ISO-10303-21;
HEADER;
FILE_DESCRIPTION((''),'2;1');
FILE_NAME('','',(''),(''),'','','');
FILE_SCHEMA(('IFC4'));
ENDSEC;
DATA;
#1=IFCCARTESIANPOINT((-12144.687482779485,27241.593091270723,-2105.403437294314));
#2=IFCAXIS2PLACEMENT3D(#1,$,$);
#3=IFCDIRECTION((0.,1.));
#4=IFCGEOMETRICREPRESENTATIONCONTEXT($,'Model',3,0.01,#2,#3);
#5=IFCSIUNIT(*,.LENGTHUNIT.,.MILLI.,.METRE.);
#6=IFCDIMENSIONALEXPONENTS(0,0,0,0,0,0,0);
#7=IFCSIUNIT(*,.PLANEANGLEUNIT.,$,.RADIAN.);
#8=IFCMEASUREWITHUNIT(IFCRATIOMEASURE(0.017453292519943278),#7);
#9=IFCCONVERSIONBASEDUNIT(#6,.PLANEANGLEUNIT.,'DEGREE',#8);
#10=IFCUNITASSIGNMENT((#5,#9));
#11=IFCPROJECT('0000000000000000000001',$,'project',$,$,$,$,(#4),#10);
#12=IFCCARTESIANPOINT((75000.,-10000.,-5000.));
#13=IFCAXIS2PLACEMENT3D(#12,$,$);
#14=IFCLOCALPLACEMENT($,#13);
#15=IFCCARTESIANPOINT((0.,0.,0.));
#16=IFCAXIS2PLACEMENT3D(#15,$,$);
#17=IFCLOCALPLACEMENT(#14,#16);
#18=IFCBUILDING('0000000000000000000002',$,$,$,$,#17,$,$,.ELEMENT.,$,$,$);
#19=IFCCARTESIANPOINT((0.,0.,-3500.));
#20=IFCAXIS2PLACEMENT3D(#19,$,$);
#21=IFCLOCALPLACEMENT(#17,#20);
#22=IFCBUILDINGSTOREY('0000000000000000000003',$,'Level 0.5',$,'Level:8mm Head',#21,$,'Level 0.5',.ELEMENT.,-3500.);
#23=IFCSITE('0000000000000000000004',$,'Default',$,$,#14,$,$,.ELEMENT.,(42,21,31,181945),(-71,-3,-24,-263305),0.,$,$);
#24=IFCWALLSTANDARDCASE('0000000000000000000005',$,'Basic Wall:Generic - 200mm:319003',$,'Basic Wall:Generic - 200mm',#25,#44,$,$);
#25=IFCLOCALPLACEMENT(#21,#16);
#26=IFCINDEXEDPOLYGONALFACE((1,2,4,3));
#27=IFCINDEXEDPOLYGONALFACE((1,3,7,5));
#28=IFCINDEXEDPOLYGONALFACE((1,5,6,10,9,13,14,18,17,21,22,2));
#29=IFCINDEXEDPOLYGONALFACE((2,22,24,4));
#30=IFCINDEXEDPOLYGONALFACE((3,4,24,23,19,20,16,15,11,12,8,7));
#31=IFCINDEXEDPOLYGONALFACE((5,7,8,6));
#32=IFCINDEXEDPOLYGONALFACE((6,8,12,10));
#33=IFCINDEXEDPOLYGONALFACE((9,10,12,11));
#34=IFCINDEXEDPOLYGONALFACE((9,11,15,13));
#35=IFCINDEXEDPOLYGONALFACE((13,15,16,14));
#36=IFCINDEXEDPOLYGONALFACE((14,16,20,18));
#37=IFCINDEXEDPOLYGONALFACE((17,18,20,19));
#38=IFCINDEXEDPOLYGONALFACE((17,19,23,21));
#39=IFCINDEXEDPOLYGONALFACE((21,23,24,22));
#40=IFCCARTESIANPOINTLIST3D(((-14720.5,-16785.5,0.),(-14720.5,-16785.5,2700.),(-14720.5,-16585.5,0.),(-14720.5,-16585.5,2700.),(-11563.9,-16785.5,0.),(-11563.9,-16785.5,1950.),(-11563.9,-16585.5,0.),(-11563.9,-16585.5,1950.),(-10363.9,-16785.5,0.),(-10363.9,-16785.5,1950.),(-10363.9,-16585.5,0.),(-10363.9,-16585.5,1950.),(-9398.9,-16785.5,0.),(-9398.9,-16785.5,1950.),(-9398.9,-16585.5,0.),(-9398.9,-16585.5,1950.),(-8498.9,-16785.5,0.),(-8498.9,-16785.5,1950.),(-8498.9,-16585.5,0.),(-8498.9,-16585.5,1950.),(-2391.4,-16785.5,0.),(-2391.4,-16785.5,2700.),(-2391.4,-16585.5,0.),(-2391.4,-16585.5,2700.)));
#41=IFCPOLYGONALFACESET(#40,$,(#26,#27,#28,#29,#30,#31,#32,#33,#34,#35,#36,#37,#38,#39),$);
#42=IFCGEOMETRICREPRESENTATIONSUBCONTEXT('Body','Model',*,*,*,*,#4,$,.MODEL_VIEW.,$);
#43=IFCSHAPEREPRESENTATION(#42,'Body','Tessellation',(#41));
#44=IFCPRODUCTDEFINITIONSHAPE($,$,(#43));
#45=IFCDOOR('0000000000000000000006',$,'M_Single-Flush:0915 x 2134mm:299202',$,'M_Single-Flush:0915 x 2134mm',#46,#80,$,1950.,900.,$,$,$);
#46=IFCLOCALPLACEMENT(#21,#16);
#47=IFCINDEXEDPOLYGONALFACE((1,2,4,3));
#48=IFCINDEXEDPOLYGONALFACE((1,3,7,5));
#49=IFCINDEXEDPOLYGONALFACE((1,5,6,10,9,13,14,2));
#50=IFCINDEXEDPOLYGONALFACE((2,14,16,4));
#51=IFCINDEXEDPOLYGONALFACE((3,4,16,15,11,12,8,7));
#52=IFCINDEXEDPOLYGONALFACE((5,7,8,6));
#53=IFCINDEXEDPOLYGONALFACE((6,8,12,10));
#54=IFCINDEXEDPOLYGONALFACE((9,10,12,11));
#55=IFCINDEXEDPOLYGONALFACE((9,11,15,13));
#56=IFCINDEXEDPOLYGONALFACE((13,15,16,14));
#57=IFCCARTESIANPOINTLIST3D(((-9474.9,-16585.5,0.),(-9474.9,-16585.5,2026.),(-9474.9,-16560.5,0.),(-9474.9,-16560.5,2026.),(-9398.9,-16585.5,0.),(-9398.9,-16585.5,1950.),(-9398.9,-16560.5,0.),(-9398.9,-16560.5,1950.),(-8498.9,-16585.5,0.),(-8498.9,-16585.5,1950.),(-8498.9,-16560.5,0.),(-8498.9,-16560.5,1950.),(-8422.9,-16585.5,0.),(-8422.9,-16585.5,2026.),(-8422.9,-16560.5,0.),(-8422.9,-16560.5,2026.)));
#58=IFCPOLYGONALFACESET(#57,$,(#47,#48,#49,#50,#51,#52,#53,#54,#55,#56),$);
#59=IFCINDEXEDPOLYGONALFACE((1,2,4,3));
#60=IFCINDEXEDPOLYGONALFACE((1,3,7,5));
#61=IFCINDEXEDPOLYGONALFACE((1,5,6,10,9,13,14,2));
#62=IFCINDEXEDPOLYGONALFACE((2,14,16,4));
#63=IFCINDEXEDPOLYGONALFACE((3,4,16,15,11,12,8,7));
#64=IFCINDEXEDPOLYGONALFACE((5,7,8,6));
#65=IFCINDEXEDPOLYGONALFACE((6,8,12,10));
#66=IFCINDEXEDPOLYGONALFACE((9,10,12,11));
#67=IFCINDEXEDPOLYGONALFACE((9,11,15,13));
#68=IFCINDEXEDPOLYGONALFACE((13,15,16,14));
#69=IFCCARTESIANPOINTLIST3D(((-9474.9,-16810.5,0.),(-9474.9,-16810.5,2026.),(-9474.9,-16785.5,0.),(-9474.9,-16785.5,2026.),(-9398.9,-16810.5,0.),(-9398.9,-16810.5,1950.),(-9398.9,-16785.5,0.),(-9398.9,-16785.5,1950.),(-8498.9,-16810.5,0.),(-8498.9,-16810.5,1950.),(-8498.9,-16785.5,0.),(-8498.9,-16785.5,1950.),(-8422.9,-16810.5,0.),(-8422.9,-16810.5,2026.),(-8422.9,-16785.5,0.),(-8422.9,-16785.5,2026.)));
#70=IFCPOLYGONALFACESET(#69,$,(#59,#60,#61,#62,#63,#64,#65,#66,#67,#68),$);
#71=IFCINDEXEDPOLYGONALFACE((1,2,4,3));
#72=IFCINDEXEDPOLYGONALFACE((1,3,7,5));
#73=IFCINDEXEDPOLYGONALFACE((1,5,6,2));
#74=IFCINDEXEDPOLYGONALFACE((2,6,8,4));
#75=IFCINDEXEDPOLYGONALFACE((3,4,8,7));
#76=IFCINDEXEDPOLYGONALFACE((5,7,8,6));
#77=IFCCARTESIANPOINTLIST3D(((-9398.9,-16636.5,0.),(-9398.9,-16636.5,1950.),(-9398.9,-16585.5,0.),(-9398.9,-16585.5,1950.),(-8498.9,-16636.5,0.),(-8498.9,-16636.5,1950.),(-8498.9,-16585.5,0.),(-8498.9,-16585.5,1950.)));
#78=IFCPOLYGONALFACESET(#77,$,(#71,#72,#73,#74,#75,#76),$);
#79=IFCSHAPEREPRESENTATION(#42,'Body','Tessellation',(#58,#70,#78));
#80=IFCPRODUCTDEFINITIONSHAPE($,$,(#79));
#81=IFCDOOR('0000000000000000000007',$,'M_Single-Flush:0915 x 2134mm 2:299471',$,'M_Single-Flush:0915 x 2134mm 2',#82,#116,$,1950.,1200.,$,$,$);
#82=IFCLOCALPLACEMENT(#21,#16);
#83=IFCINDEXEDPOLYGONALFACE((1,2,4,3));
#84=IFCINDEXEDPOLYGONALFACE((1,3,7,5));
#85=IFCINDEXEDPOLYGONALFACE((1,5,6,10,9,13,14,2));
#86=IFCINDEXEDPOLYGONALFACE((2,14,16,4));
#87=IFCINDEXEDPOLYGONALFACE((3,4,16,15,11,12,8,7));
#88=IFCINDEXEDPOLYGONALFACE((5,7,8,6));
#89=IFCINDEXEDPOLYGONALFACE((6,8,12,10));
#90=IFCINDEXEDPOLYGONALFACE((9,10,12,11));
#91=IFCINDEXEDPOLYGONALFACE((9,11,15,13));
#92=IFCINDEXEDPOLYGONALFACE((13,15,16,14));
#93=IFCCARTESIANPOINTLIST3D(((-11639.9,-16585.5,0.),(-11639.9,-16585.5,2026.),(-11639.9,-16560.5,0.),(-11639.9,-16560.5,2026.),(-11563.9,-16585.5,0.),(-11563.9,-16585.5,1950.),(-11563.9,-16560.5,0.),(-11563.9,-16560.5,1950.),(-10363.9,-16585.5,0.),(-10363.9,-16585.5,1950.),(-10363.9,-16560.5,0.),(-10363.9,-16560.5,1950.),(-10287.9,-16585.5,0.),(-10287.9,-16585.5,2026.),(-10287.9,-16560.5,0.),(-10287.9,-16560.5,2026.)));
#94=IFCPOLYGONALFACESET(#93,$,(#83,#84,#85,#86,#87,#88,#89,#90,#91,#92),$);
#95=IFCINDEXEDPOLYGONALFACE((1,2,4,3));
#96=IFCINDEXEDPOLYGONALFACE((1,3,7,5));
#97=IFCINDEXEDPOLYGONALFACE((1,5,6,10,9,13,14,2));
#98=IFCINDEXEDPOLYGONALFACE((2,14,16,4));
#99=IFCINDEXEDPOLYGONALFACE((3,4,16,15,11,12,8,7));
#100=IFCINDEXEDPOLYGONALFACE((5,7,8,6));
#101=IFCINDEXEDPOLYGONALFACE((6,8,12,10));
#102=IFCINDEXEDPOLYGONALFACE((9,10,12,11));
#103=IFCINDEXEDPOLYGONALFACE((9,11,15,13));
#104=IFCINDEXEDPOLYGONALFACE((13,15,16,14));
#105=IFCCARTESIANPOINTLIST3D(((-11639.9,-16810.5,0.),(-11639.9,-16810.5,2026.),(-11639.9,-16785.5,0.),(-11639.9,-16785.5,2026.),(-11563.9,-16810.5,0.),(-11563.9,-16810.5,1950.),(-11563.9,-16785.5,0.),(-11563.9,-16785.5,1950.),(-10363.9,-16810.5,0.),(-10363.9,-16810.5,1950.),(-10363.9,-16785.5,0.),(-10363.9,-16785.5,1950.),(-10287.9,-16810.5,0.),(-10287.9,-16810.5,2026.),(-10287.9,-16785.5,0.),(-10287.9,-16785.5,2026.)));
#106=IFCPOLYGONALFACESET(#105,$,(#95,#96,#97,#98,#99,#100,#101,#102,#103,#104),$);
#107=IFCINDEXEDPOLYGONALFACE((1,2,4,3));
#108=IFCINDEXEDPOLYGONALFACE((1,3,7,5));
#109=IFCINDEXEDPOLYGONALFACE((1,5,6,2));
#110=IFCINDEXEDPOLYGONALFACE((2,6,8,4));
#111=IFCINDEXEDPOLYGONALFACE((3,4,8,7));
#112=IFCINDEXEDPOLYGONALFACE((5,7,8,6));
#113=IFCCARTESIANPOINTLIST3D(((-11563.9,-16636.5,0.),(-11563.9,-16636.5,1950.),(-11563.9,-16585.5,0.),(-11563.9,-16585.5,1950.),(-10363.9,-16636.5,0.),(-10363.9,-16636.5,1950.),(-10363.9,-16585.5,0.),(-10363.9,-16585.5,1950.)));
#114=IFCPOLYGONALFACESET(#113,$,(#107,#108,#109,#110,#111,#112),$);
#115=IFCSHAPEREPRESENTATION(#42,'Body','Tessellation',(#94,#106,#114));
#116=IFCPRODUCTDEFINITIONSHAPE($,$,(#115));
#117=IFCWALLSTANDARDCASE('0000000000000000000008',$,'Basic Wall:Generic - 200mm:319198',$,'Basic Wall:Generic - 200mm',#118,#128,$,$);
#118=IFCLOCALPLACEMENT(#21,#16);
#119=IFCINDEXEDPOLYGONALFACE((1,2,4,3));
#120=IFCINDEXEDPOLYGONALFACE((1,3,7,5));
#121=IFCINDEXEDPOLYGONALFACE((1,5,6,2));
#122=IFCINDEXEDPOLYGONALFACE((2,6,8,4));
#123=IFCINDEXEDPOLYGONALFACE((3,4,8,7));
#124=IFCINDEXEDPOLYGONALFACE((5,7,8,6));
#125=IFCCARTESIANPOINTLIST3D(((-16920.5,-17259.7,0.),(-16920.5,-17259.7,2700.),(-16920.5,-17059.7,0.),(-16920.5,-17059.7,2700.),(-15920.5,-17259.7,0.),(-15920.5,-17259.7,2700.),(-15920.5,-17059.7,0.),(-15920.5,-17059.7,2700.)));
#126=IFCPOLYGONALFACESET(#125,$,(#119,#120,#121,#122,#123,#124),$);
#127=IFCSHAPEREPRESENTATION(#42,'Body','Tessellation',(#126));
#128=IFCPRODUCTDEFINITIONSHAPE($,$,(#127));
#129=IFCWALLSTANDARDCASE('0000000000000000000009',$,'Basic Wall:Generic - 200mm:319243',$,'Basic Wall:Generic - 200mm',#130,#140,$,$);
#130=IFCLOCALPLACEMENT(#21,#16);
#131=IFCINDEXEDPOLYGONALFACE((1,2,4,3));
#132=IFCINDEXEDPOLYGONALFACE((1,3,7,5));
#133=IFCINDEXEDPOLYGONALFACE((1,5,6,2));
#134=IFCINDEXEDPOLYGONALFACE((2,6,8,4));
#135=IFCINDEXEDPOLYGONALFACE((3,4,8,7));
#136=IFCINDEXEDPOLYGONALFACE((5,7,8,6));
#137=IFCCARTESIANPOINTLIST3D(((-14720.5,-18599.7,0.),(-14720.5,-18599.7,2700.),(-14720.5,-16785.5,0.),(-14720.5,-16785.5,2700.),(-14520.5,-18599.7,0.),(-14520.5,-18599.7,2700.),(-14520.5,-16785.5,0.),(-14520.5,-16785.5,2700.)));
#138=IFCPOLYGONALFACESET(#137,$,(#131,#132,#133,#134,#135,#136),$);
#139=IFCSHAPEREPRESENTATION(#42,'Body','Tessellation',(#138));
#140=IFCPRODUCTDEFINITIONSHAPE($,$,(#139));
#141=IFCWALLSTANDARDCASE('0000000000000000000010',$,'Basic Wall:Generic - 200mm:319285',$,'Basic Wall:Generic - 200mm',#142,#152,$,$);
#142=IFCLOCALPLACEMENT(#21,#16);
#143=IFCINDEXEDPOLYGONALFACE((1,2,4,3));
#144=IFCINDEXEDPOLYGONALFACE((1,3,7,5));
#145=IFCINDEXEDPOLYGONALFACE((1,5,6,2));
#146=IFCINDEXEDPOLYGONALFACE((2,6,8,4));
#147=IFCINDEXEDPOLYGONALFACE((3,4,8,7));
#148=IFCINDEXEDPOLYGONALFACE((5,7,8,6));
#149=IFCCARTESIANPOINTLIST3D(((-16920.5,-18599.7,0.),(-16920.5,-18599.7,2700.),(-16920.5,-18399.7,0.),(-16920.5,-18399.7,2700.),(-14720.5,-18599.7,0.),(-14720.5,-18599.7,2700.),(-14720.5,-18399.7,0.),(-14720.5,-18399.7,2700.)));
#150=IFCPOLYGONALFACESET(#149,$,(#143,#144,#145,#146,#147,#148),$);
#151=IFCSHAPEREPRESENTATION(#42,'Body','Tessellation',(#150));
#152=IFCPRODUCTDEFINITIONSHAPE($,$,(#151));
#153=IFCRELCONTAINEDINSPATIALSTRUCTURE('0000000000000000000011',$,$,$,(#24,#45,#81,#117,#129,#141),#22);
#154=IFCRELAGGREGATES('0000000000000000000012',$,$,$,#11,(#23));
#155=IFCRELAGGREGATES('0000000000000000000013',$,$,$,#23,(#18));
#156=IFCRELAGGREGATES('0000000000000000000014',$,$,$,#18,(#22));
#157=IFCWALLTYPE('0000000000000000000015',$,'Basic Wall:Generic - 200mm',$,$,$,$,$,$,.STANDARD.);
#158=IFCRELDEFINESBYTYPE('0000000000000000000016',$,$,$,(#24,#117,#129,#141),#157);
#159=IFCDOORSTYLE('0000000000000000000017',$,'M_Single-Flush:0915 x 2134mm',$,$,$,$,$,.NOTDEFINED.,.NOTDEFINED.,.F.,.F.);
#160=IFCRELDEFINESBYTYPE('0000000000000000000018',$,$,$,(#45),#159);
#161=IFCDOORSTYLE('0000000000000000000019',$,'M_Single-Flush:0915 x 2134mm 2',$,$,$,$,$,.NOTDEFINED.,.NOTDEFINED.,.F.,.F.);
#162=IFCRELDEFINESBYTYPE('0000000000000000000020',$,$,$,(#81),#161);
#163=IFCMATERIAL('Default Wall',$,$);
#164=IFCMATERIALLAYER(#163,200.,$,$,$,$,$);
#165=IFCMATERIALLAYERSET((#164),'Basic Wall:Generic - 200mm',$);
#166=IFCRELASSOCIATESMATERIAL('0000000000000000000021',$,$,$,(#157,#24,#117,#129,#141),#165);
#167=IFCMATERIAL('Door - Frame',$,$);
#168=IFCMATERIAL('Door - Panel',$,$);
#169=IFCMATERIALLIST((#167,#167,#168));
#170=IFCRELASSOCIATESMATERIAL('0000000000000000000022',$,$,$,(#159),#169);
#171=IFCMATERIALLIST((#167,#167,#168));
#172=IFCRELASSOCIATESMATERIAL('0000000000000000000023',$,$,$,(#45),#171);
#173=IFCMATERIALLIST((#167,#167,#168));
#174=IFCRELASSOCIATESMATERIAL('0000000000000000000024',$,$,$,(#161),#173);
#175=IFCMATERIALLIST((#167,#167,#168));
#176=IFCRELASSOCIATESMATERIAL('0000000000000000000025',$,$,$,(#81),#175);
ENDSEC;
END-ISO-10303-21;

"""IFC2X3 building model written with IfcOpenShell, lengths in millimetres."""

from ifc_helpers import new_model, entity, si_unit, converted_unit, direction, frame, frame_2d, origin, place, context, subcontext, project, spatial, polyline, rectangle, outline, extrude, source, transform, mapped, material, material_list, layer, layer_set, layer_usage, type_object, type_shapes, element, fill, save


model = new_model("IFC2X3")

# Units and contexts
model_context = context("Model", 3, precision=0.01, world=frame((-12144.687482779485, 27241.593091270723, -2105.403437294314)), true_north=direction((0.0, 1.0)))
body_context = subcontext(model_context, "Body", "Model", "MODEL_VIEW")
ifc_project = project(units=[si_unit("LENGTHUNIT", "METRE", prefix="MILLI"), converted_unit("PLANEANGLEUNIT", "DEGREE", entity("IfcRatioMeasure", 0.017453292519943278), si_unit("PLANEANGLEUNIT", "RADIAN"), dimensions=[0, 0, 0, 0, 0, 0, 0])], contexts=[model_context])

# Site, building, storey
site_placement = place(None, frame((75000.0, -10000.0, -5000.0)))
site = spatial("IfcSite", under=ifc_project, at=site_placement, Name="Default", CompositionType="ELEMENT", RefLatitude=(42, 21, 31, 181945), RefLongitude=(-71, -3, -24, -263305), RefElevation=0.0)
building_placement = place(site_placement, origin())
building = spatial("IfcBuilding", under=site, at=building_placement, CompositionType="ELEMENT")
storey_placement = place(building_placement, frame((0.0, 0.0, -3500.0)))
storey = spatial("IfcBuildingStorey", under=building, at=storey_placement, Name="Level 0.5", ObjectType="Level:8mm Head", LongName="Level 0.5", CompositionType="ELEMENT", Elevation=-3500.0)

# Shared definitions
ifc_material_1 = material(Name="Default Wall")
ifc_layer_1 = layer(ifc_material_1, 200.0)
ifc_layer_set_1 = layer_set([ifc_layer_1], Name="Basic Wall:Generic - 200mm")
wall_type_1 = type_object("IfcWallType", Name="Basic Wall:Generic - 200mm", PredefinedType="STANDARD", material=ifc_layer_set_1)

# Shared definitions
ifc_material_2 = material(Name="Door - Frame")
ifc_material_3 = material(Name="Door - Panel")
ifc_material_list_1 = material_list([ifc_material_2, ifc_material_2, ifc_material_3])
door_style_1 = type_object("IfcDoorStyle", Name="M_Single-Flush:0915 x 2134mm", ConstructionType="NOTDEFINED", OperationType="NOTDEFINED", ParameterTakesPrecedence=False, Sizeable=False, material=ifc_material_list_1)
shared_shape_1 = source(origin(), body_context, "Body", "SweptSolid", [
    extrude(outline(polyline([(-526.0, -1032.0), (526.0, -1032.0), (526.0, 994.0), (450.0, 994.0), (450.0, -956.0), (-450.0, -956.0), (-450.0, 994.0), (-526.0, 994.0), (-526.0, -1032.0)])), frame((450.0, 225.0, 994.0), z_axis=(0.0, -1.0, 0.0), x_axis=(-1.0, 0.0, 0.0)), (0.0, 0.0, 1.0), 25.0),
    extrude(outline(polyline([(-1032.0, -526.0), (994.0, -526.0), (994.0, -450.0), (-956.0, -450.0), (-956.0, 450.0), (994.0, 450.0), (994.0, 526.0), (-1032.0, 526.0), (-1032.0, -526.0)])), frame((450.0, 0.0, 994.0), z_axis=(0.0, -1.0, 0.0), x_axis=(0.0, 0.0, -1.0)), (0.0, 0.0, 1.0), 25.0),
    extrude(rectangle(XDim=900.0, YDim=51.0, at=frame_2d((0.0, 0.0), x_axis=(1.0, 0.0))), frame((450.0, 174.5, 0.0)), (0.0, 0.0, 1.0), 1950.0),
])
type_shapes(door_style_1, [shared_shape_1])

# Wall, openings, doors
ifc_layer_usage_1 = layer_usage(ifc_layer_set_1, "AXIS2", "NEGATIVE", 100.0)
wall_1_placement = place(storey_placement, frame((-14720.5, -16685.5, 0.0)))
wall_1 = element("IfcWallStandardCase", 1, at=wall_1_placement, inside=storey, type_object=wall_type_1, material=ifc_layer_usage_1, Name="Basic Wall:Generic - 200mm:319003", ObjectType="Basic Wall:Generic - 200mm", context=body_context, shape_type="SweptSolid", body=[
    extrude(rectangle(XDim=12329.1, YDim=200.0, at=frame_2d((6164.6, 0.0), x_axis=(1.0, 0.0))), origin(), (0.0, 0.0, 1.0), 2700.0),
])
opening_1_placement = place(wall_1_placement, frame((5321.6, -100.0, 0.0)))
opening_1 = element("IfcOpeningElement", 2, at=opening_1_placement, cuts=wall_1, ObjectType="Opening", context=body_context, shape_type="SweptSolid", body=[
    extrude(rectangle(XDim=900.0, YDim=1950.0, at=frame_2d((975.0, 450.0), x_axis=(0.0, -1.0))), frame((0.0, 0.0, 0.0), z_axis=(0.0, 1.0, 0.0), x_axis=(0.0, 0.0, 1.0)), (0.0, 0.0, 1.0), 200.0),
])
opening_2_placement = place(wall_1_placement, frame((3156.6, -100.0, 0.0)))
opening_2 = element("IfcOpeningElement", 3, at=opening_2_placement, cuts=wall_1, ObjectType="Opening", context=body_context, shape_type="SweptSolid", body=[
    extrude(rectangle(XDim=1200.0, YDim=1950.0, at=frame_2d((975.0, 600.0), x_axis=(0.0, -1.0))), frame((0.0, 0.0, 0.0), z_axis=(0.0, 1.0, 0.0), x_axis=(0.0, 0.0, 1.0)), (0.0, 0.0, 1.0), 200.0),
])
ifc_material_list_2 = material_list([ifc_material_2, ifc_material_2, ifc_material_3])
door_1_placement = place(opening_1_placement, origin())
door_1 = element("IfcDoor", 4, at=door_1_placement, inside=storey, type_object=door_style_1, material=ifc_material_list_2, Name="M_Single-Flush:0915 x 2134mm:299202", ObjectType="M_Single-Flush:0915 x 2134mm", OverallHeight=1950.0, OverallWidth=900.0, context=body_context, shape_type="MappedRepresentation", body=[
    mapped(shared_shape_1, transform((0.0, 0.0, 0.0), scale=1.0)),
])
fill(opening_1, door_1)
ifc_material_list_3 = material_list([ifc_material_2, ifc_material_2, ifc_material_3])
ifc_material_list_4 = material_list([ifc_material_2, ifc_material_2, ifc_material_3])
door_style_2 = type_object("IfcDoorStyle", Name="M_Single-Flush:0915 x 2134mm 2", ConstructionType="NOTDEFINED", OperationType="NOTDEFINED", ParameterTakesPrecedence=False, Sizeable=False, material=ifc_material_list_4)
shared_shape_2 = source(origin(), body_context, "Body", "SweptSolid", [
    extrude(outline(polyline([(-676.0, -1032.0), (676.0, -1032.0), (676.0, 994.0), (600.0, 994.0), (600.0, -956.0), (-600.0, -956.0), (-600.0, 994.0), (-676.0, 994.0), (-676.0, -1032.0)])), frame((600.0, 225.0, 994.0), z_axis=(0.0, -1.0, 0.0), x_axis=(-1.0, 0.0, 0.0)), (0.0, 0.0, 1.0), 25.0),
    extrude(outline(polyline([(-1032.0, -676.0), (994.0, -676.0), (994.0, -600.0), (-956.0, -600.0), (-956.0, 600.0), (994.0, 600.0), (994.0, 676.0), (-1032.0, 676.0), (-1032.0, -676.0)])), frame((600.0, 0.0, 994.0), z_axis=(0.0, -1.0, 0.0), x_axis=(0.0, 0.0, -1.0)), (0.0, 0.0, 1.0), 25.0),
    extrude(rectangle(XDim=1200.0, YDim=51.0, at=frame_2d((0.0, 0.0), x_axis=(1.0, 0.0))), frame((600.0, 174.5, 0.0)), (0.0, 0.0, 1.0), 1950.0),
])
type_shapes(door_style_2, [shared_shape_2])
door_2_placement = place(opening_2_placement, origin())
door_2 = element("IfcDoor", 5, at=door_2_placement, inside=storey, type_object=door_style_2, material=ifc_material_list_3, Name="M_Single-Flush:0915 x 2134mm 2:299471", ObjectType="M_Single-Flush:0915 x 2134mm 2", OverallHeight=1950.0, OverallWidth=1200.0, context=body_context, shape_type="MappedRepresentation", body=[
    mapped(shared_shape_2, transform((0.0, 0.0, 0.0), scale=1.0)),
])
fill(opening_2, door_2)

# Walls
ifc_layer_usage_2 = layer_usage(ifc_layer_set_1, "AXIS2", "NEGATIVE", 100.0)
wall_2_placement = place(storey_placement, frame((-15920.5, -17159.7, 0.0), z_axis=(0.0, 0.0, 1.0), x_axis=(-1.0, 0.0, 0.0)))
element("IfcWallStandardCase", 6, at=wall_2_placement, inside=storey, type_object=wall_type_1, material=ifc_layer_usage_2, Name="Basic Wall:Generic - 200mm:319198", ObjectType="Basic Wall:Generic - 200mm", context=body_context, shape_type="SweptSolid", body=[
    extrude(rectangle(XDim=1000.0, YDim=200.0, at=frame_2d((500.0, 0.0), x_axis=(-1.0, 0.0))), origin(), (0.0, 0.0, 1.0), 2700.0),
])
ifc_layer_usage_3 = layer_usage(ifc_layer_set_1, "AXIS2", "NEGATIVE", 100.0)
wall_3_placement = place(storey_placement, frame((-14620.5, -16785.5, 0.0), z_axis=(0.0, 0.0, 1.0), x_axis=(0.0, -1.0, 0.0)))
element("IfcWallStandardCase", 7, at=wall_3_placement, inside=storey, type_object=wall_type_1, material=ifc_layer_usage_3, Name="Basic Wall:Generic - 200mm:319243", ObjectType="Basic Wall:Generic - 200mm", context=body_context, shape_type="SweptSolid", body=[
    extrude(rectangle(XDim=1814.2, YDim=200.0, at=frame_2d((907.1, 0.0), x_axis=(-1.0, 0.0))), origin(), (0.0, 0.0, 1.0), 2700.0),
])
ifc_layer_usage_4 = layer_usage(ifc_layer_set_1, "AXIS2", "NEGATIVE", 100.0)
wall_4_placement = place(storey_placement, frame((-14720.5, -18499.7, 0.0), z_axis=(0.0, 0.0, 1.0), x_axis=(-1.0, 0.0, 0.0)))
element("IfcWallStandardCase", 8, at=wall_4_placement, inside=storey, type_object=wall_type_1, material=ifc_layer_usage_4, Name="Basic Wall:Generic - 200mm:319285", ObjectType="Basic Wall:Generic - 200mm", context=body_context, shape_type="SweptSolid", body=[
    extrude(rectangle(XDim=2200.0, YDim=200.0, at=frame_2d((1100.0, 0.0), x_axis=(-1.0, 0.0))), origin(), (0.0, 0.0, 1.0), 2700.0),
])

save(model, "model.ifc")
